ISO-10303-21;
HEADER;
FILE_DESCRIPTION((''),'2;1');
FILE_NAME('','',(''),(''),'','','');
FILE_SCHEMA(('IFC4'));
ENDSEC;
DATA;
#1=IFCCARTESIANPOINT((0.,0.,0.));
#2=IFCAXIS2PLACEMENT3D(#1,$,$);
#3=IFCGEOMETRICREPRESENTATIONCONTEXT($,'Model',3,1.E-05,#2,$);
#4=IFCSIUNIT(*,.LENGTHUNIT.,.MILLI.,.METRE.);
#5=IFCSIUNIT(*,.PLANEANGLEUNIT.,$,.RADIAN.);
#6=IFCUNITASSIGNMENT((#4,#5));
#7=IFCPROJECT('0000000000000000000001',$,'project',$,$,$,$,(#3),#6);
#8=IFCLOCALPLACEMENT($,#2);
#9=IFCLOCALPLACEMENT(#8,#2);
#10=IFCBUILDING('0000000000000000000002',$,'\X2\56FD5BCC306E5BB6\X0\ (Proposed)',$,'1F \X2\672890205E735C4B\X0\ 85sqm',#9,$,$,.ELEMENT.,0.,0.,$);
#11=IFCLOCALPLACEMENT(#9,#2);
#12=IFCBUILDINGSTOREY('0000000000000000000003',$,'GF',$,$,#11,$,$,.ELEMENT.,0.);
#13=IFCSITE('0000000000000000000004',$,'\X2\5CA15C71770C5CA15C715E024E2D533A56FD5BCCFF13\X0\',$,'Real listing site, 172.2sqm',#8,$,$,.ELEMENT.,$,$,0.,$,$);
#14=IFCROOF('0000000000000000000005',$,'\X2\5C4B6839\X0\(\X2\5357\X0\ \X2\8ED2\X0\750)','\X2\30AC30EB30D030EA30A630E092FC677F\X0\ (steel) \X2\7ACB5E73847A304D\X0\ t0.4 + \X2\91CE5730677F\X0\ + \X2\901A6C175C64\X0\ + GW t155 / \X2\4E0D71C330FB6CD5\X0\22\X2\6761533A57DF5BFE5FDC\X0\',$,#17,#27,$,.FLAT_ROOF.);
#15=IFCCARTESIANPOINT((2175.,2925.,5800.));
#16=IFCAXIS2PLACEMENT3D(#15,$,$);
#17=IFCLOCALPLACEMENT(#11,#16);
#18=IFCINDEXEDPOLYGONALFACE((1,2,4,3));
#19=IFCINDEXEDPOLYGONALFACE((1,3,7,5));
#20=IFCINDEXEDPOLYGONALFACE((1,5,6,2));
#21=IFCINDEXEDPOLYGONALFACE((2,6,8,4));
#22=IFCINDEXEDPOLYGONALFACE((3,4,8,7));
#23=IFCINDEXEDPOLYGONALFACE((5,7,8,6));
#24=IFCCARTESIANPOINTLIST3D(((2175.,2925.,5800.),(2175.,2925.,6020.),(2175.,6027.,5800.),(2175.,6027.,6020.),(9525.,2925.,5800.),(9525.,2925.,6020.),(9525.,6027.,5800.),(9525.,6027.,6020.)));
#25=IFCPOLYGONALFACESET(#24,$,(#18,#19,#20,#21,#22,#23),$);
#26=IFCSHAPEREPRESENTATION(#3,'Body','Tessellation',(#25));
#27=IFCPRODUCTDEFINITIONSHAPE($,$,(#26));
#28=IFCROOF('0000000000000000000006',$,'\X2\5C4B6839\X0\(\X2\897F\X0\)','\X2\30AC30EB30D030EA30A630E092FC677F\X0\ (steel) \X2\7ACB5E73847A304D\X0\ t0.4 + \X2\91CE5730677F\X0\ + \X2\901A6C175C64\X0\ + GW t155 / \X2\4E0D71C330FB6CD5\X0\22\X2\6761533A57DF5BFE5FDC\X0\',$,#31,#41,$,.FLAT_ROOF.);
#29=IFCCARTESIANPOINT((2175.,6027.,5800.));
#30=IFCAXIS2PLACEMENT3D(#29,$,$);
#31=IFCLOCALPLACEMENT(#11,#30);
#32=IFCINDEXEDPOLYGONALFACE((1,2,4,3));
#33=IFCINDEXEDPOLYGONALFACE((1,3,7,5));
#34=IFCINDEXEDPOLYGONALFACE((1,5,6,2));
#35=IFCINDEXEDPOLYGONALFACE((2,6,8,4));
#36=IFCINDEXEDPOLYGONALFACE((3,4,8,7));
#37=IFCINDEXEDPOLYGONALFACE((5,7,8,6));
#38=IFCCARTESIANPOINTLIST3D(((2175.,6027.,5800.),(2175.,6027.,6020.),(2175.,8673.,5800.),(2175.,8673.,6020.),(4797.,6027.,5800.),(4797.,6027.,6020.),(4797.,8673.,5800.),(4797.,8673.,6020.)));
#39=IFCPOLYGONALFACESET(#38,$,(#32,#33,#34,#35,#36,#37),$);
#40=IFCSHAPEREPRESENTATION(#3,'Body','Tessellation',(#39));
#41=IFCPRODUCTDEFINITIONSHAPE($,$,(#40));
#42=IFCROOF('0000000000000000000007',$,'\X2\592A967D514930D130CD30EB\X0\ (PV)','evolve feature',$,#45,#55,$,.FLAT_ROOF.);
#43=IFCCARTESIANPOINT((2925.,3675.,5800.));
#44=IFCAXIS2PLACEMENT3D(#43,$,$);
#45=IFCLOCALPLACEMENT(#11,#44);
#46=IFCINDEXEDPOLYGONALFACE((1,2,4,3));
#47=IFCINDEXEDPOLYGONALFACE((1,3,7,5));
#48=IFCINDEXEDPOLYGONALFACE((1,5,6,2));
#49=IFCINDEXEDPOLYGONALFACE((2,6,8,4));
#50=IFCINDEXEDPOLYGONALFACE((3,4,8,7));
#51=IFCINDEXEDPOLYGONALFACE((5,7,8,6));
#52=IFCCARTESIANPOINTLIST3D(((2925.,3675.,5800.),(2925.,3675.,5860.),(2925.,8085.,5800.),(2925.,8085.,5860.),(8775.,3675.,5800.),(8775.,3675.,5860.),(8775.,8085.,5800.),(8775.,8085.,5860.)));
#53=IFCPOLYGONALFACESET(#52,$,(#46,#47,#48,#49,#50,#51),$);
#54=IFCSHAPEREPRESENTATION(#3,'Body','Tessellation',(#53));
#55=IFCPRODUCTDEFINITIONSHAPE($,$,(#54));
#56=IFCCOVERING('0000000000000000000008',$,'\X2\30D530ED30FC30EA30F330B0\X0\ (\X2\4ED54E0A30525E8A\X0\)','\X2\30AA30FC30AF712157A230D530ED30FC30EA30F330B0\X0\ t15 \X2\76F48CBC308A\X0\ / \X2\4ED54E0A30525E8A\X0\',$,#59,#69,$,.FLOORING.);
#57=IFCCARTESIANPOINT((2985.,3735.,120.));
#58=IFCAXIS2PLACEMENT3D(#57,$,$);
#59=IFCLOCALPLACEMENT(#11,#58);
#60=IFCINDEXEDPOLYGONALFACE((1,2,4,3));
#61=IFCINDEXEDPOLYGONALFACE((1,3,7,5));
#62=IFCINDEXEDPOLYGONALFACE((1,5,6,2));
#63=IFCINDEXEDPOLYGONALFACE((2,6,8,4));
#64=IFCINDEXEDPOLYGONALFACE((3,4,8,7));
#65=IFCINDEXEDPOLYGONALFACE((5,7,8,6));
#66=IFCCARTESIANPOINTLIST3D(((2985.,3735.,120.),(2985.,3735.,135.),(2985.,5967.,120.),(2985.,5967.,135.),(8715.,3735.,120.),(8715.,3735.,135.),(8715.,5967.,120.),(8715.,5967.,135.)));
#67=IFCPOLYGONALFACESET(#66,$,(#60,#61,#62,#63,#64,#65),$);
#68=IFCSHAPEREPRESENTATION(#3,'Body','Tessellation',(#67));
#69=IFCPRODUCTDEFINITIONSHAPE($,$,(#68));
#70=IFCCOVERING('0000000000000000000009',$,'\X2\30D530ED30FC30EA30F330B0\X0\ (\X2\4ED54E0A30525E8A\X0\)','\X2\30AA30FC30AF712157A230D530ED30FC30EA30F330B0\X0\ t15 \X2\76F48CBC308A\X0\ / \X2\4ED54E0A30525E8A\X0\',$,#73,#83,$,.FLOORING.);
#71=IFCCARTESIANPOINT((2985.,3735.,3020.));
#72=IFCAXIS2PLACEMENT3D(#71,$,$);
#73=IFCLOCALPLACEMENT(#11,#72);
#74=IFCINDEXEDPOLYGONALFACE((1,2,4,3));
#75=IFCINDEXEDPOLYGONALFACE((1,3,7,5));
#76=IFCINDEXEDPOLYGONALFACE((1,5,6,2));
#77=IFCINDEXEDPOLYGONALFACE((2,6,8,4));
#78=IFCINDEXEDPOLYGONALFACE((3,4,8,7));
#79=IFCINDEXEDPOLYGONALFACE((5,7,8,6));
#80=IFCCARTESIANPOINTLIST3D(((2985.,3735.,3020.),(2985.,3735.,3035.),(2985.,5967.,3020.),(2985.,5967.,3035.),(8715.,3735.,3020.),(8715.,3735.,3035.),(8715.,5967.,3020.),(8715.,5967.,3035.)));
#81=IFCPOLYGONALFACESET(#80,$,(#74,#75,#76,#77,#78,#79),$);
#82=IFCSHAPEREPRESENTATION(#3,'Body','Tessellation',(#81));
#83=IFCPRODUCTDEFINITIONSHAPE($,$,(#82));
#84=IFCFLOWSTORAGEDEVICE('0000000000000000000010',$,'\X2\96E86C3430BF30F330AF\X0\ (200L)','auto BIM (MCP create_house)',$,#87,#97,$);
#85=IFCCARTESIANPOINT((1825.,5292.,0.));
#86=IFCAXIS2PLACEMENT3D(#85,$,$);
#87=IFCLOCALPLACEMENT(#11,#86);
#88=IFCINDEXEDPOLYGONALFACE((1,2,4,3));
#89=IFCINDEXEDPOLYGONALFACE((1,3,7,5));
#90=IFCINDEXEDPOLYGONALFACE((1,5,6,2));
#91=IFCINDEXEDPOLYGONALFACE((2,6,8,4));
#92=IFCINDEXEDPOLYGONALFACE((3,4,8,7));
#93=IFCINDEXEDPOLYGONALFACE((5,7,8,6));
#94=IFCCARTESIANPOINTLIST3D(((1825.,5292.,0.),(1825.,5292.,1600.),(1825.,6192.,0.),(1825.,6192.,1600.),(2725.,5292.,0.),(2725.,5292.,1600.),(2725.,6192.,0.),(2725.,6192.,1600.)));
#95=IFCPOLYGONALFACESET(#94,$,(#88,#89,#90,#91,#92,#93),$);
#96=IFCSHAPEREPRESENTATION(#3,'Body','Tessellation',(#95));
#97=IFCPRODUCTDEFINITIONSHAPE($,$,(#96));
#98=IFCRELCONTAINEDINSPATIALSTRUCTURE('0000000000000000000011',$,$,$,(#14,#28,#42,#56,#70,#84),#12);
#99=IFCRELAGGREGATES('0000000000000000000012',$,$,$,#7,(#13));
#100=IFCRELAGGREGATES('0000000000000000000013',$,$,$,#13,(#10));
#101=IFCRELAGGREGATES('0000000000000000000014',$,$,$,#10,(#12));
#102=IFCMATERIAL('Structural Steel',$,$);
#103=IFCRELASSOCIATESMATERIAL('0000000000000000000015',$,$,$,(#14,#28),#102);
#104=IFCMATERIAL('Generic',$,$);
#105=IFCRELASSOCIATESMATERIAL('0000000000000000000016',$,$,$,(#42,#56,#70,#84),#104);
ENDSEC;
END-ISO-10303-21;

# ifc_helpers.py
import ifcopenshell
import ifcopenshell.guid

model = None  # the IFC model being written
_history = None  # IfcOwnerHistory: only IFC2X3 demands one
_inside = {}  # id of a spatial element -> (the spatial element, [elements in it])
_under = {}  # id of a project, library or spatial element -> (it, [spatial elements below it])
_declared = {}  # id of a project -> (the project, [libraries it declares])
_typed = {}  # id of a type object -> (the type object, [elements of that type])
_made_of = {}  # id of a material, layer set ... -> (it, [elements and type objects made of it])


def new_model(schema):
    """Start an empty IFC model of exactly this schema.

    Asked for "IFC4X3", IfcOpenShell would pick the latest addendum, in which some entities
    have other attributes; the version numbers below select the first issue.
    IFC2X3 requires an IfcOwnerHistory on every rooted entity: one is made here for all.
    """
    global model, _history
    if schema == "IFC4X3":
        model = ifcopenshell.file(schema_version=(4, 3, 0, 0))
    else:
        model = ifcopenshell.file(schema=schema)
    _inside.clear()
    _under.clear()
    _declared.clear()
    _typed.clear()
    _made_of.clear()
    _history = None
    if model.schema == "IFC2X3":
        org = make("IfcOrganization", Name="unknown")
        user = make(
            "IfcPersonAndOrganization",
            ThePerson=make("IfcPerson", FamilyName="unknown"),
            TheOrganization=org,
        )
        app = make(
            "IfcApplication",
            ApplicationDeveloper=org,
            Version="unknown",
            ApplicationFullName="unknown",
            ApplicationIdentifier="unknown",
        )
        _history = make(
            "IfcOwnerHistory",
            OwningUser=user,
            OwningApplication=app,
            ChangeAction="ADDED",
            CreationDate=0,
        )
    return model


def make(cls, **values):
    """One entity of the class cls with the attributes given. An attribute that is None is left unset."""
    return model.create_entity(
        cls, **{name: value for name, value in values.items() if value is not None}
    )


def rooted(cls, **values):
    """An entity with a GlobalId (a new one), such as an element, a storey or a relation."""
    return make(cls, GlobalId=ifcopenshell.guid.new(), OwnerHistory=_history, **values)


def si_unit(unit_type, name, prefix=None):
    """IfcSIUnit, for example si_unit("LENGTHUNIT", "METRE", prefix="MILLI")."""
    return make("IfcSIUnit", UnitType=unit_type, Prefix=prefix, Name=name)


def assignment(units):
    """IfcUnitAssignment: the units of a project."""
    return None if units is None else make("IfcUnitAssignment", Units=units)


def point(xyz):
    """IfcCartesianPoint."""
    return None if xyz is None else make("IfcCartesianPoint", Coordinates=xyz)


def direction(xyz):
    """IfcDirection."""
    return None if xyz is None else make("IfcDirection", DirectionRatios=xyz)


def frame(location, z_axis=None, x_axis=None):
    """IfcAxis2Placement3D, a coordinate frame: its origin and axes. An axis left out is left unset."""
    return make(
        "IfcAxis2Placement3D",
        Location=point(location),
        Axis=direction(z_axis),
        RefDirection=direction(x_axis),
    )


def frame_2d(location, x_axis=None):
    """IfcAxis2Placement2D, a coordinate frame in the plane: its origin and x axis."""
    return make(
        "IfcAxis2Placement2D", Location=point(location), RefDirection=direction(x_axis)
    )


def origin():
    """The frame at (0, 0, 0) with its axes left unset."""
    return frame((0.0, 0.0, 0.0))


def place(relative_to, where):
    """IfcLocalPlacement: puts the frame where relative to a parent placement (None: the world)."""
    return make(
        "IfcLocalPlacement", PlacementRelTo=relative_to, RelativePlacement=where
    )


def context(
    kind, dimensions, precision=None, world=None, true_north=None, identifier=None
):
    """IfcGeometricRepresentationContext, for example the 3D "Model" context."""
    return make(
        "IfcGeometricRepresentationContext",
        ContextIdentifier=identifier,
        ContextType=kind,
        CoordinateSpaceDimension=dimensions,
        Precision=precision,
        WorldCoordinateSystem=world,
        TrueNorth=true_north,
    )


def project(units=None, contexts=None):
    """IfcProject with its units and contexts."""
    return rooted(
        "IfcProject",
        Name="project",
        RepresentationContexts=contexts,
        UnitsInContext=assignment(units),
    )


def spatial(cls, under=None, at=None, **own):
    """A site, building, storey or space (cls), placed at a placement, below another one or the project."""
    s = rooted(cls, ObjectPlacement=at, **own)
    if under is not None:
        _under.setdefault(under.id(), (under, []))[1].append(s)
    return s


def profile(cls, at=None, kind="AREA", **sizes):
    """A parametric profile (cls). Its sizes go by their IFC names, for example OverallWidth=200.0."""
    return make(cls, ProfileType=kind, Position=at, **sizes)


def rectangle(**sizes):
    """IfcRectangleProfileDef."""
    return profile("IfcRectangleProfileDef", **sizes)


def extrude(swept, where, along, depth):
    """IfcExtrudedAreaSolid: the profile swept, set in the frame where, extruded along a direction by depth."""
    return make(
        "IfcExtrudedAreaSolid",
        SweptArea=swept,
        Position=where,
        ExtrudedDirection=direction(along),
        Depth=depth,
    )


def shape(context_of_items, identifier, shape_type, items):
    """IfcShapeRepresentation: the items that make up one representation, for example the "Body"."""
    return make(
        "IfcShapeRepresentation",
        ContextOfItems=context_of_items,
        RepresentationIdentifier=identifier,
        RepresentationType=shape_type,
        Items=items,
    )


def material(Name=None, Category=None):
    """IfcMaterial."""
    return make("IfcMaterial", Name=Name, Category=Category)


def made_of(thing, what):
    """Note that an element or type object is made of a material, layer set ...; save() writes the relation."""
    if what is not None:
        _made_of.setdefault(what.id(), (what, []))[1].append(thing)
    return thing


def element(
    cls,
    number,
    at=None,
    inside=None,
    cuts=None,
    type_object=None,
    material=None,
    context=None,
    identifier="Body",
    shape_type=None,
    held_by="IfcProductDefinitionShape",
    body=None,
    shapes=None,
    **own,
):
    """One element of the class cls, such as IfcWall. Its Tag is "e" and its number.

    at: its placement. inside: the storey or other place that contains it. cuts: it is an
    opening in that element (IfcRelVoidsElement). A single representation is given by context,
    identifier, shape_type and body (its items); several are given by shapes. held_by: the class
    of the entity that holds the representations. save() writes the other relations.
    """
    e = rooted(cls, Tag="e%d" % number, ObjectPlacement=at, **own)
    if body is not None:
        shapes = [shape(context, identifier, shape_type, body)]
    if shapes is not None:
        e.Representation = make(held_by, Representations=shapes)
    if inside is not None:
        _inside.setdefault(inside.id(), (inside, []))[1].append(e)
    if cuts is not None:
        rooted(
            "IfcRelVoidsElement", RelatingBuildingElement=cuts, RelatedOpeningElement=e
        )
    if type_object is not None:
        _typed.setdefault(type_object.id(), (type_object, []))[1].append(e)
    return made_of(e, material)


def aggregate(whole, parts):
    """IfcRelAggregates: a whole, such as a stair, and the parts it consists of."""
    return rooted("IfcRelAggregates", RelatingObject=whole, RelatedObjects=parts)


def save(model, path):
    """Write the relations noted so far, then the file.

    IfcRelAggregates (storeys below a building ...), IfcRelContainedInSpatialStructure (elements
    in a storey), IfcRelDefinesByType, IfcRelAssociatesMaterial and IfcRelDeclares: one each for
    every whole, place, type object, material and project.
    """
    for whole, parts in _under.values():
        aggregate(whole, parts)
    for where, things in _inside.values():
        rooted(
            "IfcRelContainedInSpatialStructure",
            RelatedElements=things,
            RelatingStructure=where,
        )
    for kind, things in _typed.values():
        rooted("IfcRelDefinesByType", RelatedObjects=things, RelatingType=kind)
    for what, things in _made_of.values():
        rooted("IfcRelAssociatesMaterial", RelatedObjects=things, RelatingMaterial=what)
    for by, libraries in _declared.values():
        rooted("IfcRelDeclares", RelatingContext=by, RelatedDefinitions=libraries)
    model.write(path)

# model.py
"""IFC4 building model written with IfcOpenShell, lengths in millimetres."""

from ifc_helpers import new_model, si_unit, frame, frame_2d, origin, place, context, project, spatial, rectangle, extrude, material, element, save


model = new_model("IFC4")

# Units and contexts
model_context = context("Model", 3, precision=1e-05, world=origin())
ifc_project = project(units=[si_unit("LENGTHUNIT", "METRE", prefix="MILLI"), si_unit("PLANEANGLEUNIT", "RADIAN")], contexts=[model_context])

# Site, building, storey
site_placement = place(None, origin())
site = spatial("IfcSite", under=ifc_project, at=site_placement, Name="岡山県岡山市中区国富３", ObjectType="Real listing site, 172.2sqm", CompositionType="ELEMENT", RefElevation=0.0)
building_placement = place(site_placement, origin())
building = spatial("IfcBuilding", under=site, at=building_placement, Name="国富の家 (Proposed)", ObjectType="1F 木造平屋 85sqm", CompositionType="ELEMENT", ElevationOfRefHeight=0.0, ElevationOfTerrain=0.0)
storey_placement = place(building_placement, origin())
storey = spatial("IfcBuildingStorey", under=building, at=storey_placement, Name="GF", CompositionType="ELEMENT", Elevation=0.0)

# Shared definitions
ifc_material_1 = material(Name="Generic")

# Roofs
ifc_material_2 = material(Name="Structural Steel")
roof_1_placement = place(storey_placement, frame((2175.0, 2925.0, 5800.0)))
element("IfcRoof", 1, at=roof_1_placement, inside=storey, material=ifc_material_2, Name="屋根(南 軒750)", Description="ガルバリウム鋼板 (steel) 立平葺き t0.4 + 野地板 + 通気層 + GW t155 / 不燃・法22条区域対応", PredefinedType="FLAT_ROOF", context=model_context, shape_type="SweptSolid", body=[
    extrude(rectangle(XDim=7350.0, YDim=3102.0, at=frame_2d((3675.0, 1551.0))), frame((2175.0, 2925.0, 5800.0)), (0.0, 0.0, 1.0), 220.0),
])
roof_2_placement = place(storey_placement, frame((2175.0, 6027.0, 5800.0)))
element("IfcRoof", 2, at=roof_2_placement, inside=storey, material=ifc_material_2, Name="屋根(西)", Description="ガルバリウム鋼板 (steel) 立平葺き t0.4 + 野地板 + 通気層 + GW t155 / 不燃・法22条区域対応", PredefinedType="FLAT_ROOF", context=model_context, shape_type="SweptSolid", body=[
    extrude(rectangle(XDim=2622.0, YDim=2646.0, at=frame_2d((1311.0, 1323.0))), frame((2175.0, 6027.0, 5800.0)), (0.0, 0.0, 1.0), 220.0),
])
roof_3_placement = place(storey_placement, frame((2925.0, 3675.0, 5800.0)))
element("IfcRoof", 3, at=roof_3_placement, inside=storey, material=ifc_material_1, Name="太陽光パネル (PV)", Description="evolve feature", PredefinedType="FLAT_ROOF", context=model_context, shape_type="SweptSolid", body=[
    extrude(rectangle(XDim=5850.0, YDim=4410.0, at=frame_2d((2925.0, 2205.0))), frame((2925.0, 3675.0, 5800.0)), (0.0, 0.0, 1.0), 60.0),
])

# Coverings
covering_1_placement = place(storey_placement, frame((2985.0, 3735.0, 120.0)))
element("IfcCovering", 4, at=covering_1_placement, inside=storey, material=ifc_material_1, Name="フローリング (仕上げ床)", Description="オーク無垢フローリング t15 直貼り / 仕上げ床", PredefinedType="FLOORING", context=model_context, shape_type="SweptSolid", body=[
    extrude(rectangle(XDim=5730.0, YDim=2232.0, at=frame_2d((2865.0, 1116.0))), frame((2985.0, 3735.0, 120.0)), (0.0, 0.0, 1.0), 15.0),
])
covering_2_placement = place(storey_placement, frame((2985.0, 3735.0, 3020.0)))
element("IfcCovering", 5, at=covering_2_placement, inside=storey, material=ifc_material_1, Name="フローリング (仕上げ床)", Description="オーク無垢フローリング t15 直貼り / 仕上げ床", PredefinedType="FLOORING", context=model_context, shape_type="SweptSolid", body=[
    extrude(rectangle(XDim=5730.0, YDim=2232.0, at=frame_2d((2865.0, 1116.0))), frame((2985.0, 3735.0, 3020.0)), (0.0, 0.0, 1.0), 15.0),
])

# Flow storage device
flow_storage_device_placement = place(storey_placement, frame((1825.0, 5292.0, 0.0)))
element("IfcFlowStorageDevice", 6, at=flow_storage_device_placement, inside=storey, material=ifc_material_1, Name="雨水タンク (200L)", Description="auto BIM (MCP create_house)", context=model_context, shape_type="SweptSolid", body=[
    extrude(rectangle(XDim=900.0, YDim=900.0, at=frame_2d((450.0, 450.0))), frame((1825.0, 5292.0, 0.0)), (0.0, 0.0, 1.0), 1600.0),
])

save(model, "model.ifc")
